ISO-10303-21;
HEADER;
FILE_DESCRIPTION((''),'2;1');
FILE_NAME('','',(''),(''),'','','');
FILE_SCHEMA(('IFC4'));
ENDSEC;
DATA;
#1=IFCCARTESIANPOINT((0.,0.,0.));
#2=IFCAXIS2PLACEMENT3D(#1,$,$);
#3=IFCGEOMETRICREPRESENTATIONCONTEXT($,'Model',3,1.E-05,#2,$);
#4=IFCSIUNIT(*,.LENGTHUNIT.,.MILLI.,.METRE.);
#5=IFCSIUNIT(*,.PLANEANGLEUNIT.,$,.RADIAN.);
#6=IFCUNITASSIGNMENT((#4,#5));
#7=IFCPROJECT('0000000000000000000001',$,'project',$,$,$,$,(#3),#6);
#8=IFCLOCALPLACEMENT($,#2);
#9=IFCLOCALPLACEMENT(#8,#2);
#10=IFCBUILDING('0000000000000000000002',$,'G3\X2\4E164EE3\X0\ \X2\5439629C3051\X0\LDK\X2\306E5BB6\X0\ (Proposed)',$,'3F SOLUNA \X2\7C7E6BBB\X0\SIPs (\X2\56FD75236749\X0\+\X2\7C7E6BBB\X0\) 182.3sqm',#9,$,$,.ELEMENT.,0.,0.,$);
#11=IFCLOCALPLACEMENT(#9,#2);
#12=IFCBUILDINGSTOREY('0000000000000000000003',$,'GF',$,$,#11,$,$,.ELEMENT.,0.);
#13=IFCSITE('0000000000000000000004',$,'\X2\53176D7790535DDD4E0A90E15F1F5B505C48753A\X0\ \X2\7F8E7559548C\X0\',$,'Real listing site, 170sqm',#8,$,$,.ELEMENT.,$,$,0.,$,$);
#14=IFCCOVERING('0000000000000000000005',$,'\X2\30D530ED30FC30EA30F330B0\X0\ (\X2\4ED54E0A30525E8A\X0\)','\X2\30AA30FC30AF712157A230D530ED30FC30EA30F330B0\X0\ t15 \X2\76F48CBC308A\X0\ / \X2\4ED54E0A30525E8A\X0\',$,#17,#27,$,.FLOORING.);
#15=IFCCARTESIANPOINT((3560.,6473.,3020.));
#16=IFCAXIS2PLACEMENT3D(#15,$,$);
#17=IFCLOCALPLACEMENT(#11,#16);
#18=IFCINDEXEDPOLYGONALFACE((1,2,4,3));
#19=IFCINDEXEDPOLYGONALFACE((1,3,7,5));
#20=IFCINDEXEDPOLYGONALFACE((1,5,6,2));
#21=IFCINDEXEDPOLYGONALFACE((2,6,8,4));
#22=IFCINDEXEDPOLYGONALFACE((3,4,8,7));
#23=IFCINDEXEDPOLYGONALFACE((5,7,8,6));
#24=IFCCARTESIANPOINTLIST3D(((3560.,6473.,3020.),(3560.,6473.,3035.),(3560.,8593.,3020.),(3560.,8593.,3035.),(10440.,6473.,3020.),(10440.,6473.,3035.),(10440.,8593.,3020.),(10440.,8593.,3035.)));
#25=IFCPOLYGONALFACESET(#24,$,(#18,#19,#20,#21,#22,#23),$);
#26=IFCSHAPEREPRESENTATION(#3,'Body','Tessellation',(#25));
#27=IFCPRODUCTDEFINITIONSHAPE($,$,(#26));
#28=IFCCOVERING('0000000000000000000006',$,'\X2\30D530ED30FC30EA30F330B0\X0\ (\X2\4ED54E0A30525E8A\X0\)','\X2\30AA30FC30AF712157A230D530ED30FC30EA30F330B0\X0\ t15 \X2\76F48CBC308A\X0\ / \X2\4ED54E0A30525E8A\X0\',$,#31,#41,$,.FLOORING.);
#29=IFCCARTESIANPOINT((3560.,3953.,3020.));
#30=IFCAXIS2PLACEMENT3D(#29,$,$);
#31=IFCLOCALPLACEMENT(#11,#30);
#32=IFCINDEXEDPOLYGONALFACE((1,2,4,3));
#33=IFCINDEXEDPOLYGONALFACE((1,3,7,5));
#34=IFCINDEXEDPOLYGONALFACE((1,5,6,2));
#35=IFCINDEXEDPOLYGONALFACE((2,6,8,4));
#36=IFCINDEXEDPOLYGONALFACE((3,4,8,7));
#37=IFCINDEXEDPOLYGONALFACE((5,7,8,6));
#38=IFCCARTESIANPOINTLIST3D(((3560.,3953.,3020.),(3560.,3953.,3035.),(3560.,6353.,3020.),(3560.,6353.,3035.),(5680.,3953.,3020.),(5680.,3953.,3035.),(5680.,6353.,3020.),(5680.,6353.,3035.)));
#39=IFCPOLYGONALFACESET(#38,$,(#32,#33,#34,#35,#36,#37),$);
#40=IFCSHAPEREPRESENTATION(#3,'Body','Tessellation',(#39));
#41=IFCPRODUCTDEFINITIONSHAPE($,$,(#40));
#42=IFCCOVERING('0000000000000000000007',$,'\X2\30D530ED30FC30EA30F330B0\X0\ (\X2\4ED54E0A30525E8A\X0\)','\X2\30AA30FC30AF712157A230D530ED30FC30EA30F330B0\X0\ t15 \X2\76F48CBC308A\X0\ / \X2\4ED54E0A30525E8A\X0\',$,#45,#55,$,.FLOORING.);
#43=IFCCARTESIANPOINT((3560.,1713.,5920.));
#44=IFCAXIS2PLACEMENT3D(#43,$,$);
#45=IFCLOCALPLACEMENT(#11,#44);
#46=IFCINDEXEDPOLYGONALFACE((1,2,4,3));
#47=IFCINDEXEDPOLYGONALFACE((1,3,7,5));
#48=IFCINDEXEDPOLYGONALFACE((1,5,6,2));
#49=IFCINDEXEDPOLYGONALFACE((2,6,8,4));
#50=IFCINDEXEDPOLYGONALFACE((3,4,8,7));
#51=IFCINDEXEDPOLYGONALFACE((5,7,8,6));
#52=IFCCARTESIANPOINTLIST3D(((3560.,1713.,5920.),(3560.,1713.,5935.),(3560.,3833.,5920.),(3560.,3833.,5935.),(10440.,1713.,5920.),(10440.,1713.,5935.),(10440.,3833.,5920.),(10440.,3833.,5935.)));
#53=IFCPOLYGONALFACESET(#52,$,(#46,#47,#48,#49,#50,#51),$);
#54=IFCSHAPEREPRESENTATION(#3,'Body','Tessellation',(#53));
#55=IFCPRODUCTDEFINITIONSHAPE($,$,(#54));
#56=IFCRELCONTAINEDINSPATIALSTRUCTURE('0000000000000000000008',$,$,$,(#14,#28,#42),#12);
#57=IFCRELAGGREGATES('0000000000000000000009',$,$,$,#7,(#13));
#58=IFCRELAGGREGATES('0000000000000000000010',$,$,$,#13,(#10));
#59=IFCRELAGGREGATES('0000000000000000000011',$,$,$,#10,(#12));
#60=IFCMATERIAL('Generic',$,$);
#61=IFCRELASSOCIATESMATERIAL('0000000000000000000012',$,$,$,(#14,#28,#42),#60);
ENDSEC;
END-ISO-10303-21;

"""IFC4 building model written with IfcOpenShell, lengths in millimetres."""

from ifc_helpers import new_model, si_unit, frame, frame_2d, origin, place, context, project, spatial, rectangle, extrude, material, element, save


model = new_model("IFC4")

# Units and contexts
model_context = context("Model", 3, precision=1e-05, world=origin())
ifc_project = project(units=[si_unit("LENGTHUNIT", "METRE", prefix="MILLI"), si_unit("PLANEANGLEUNIT", "RADIAN")], contexts=[model_context])

# Site, building, storey
site_placement = place(None, origin())
site = spatial("IfcSite", under=ifc_project, at=site_placement, Name="北海道川上郡弟子屈町 美留和", ObjectType="Real listing site, 170sqm", CompositionType="ELEMENT", RefElevation=0.0)
building_placement = place(site_placement, origin())
building = spatial("IfcBuilding", under=site, at=building_placement, Name="G3世代 吹抜けLDKの家 (Proposed)", ObjectType="3F SOLUNA 籾殻SIPs (国産杉+籾殻) 182.3sqm", CompositionType="ELEMENT", ElevationOfRefHeight=0.0, ElevationOfTerrain=0.0)
storey_placement = place(building_placement, origin())
storey = spatial("IfcBuildingStorey", under=building, at=storey_placement, Name="GF", CompositionType="ELEMENT", Elevation=0.0)

# Shared definitions
ifc_material_1 = material(Name="Generic")

# Coverings
covering_1_placement = place(storey_placement, frame((3560.0, 6473.0, 3020.0)))
element("IfcCovering", 1, at=covering_1_placement, inside=storey, material=ifc_material_1, Name="フローリング (仕上げ床)", Description="オーク無垢フローリング t15 直貼り / 仕上げ床", PredefinedType="FLOORING", context=model_context, shape_type="SweptSolid", body=[
    extrude(rectangle(XDim=6880.0, YDim=2120.0, at=frame_2d((3440.0, 1060.0))), frame((3560.0, 6473.0, 3020.0)), (0.0, 0.0, 1.0), 15.0),
])
covering_2_placement = place(storey_placement, frame((3560.0, 3953.0, 3020.0)))
element("IfcCovering", 2, at=covering_2_placement, inside=storey, material=ifc_material_1, Name="フローリング (仕上げ床)", Description="オーク無垢フローリング t15 直貼り / 仕上げ床", PredefinedType="FLOORING", context=model_context, shape_type="SweptSolid", body=[
    extrude(rectangle(XDim=2120.0, YDim=2400.0, at=frame_2d((1060.0, 1200.0))), frame((3560.0, 3953.0, 3020.0)), (0.0, 0.0, 1.0), 15.0),
])
covering_3_placement = place(storey_placement, frame((3560.0, 1713.0, 5920.0)))
element("IfcCovering", 3, at=covering_3_placement, inside=storey, material=ifc_material_1, Name="フローリング (仕上げ床)", Description="オーク無垢フローリング t15 直貼り / 仕上げ床", PredefinedType="FLOORING", context=model_context, shape_type="SweptSolid", body=[
    extrude(rectangle(XDim=6880.0, YDim=2120.0, at=frame_2d((3440.0, 1060.0))), frame((3560.0, 1713.0, 5920.0)), (0.0, 0.0, 1.0), 15.0),
])

save(model, "model.ifc")
